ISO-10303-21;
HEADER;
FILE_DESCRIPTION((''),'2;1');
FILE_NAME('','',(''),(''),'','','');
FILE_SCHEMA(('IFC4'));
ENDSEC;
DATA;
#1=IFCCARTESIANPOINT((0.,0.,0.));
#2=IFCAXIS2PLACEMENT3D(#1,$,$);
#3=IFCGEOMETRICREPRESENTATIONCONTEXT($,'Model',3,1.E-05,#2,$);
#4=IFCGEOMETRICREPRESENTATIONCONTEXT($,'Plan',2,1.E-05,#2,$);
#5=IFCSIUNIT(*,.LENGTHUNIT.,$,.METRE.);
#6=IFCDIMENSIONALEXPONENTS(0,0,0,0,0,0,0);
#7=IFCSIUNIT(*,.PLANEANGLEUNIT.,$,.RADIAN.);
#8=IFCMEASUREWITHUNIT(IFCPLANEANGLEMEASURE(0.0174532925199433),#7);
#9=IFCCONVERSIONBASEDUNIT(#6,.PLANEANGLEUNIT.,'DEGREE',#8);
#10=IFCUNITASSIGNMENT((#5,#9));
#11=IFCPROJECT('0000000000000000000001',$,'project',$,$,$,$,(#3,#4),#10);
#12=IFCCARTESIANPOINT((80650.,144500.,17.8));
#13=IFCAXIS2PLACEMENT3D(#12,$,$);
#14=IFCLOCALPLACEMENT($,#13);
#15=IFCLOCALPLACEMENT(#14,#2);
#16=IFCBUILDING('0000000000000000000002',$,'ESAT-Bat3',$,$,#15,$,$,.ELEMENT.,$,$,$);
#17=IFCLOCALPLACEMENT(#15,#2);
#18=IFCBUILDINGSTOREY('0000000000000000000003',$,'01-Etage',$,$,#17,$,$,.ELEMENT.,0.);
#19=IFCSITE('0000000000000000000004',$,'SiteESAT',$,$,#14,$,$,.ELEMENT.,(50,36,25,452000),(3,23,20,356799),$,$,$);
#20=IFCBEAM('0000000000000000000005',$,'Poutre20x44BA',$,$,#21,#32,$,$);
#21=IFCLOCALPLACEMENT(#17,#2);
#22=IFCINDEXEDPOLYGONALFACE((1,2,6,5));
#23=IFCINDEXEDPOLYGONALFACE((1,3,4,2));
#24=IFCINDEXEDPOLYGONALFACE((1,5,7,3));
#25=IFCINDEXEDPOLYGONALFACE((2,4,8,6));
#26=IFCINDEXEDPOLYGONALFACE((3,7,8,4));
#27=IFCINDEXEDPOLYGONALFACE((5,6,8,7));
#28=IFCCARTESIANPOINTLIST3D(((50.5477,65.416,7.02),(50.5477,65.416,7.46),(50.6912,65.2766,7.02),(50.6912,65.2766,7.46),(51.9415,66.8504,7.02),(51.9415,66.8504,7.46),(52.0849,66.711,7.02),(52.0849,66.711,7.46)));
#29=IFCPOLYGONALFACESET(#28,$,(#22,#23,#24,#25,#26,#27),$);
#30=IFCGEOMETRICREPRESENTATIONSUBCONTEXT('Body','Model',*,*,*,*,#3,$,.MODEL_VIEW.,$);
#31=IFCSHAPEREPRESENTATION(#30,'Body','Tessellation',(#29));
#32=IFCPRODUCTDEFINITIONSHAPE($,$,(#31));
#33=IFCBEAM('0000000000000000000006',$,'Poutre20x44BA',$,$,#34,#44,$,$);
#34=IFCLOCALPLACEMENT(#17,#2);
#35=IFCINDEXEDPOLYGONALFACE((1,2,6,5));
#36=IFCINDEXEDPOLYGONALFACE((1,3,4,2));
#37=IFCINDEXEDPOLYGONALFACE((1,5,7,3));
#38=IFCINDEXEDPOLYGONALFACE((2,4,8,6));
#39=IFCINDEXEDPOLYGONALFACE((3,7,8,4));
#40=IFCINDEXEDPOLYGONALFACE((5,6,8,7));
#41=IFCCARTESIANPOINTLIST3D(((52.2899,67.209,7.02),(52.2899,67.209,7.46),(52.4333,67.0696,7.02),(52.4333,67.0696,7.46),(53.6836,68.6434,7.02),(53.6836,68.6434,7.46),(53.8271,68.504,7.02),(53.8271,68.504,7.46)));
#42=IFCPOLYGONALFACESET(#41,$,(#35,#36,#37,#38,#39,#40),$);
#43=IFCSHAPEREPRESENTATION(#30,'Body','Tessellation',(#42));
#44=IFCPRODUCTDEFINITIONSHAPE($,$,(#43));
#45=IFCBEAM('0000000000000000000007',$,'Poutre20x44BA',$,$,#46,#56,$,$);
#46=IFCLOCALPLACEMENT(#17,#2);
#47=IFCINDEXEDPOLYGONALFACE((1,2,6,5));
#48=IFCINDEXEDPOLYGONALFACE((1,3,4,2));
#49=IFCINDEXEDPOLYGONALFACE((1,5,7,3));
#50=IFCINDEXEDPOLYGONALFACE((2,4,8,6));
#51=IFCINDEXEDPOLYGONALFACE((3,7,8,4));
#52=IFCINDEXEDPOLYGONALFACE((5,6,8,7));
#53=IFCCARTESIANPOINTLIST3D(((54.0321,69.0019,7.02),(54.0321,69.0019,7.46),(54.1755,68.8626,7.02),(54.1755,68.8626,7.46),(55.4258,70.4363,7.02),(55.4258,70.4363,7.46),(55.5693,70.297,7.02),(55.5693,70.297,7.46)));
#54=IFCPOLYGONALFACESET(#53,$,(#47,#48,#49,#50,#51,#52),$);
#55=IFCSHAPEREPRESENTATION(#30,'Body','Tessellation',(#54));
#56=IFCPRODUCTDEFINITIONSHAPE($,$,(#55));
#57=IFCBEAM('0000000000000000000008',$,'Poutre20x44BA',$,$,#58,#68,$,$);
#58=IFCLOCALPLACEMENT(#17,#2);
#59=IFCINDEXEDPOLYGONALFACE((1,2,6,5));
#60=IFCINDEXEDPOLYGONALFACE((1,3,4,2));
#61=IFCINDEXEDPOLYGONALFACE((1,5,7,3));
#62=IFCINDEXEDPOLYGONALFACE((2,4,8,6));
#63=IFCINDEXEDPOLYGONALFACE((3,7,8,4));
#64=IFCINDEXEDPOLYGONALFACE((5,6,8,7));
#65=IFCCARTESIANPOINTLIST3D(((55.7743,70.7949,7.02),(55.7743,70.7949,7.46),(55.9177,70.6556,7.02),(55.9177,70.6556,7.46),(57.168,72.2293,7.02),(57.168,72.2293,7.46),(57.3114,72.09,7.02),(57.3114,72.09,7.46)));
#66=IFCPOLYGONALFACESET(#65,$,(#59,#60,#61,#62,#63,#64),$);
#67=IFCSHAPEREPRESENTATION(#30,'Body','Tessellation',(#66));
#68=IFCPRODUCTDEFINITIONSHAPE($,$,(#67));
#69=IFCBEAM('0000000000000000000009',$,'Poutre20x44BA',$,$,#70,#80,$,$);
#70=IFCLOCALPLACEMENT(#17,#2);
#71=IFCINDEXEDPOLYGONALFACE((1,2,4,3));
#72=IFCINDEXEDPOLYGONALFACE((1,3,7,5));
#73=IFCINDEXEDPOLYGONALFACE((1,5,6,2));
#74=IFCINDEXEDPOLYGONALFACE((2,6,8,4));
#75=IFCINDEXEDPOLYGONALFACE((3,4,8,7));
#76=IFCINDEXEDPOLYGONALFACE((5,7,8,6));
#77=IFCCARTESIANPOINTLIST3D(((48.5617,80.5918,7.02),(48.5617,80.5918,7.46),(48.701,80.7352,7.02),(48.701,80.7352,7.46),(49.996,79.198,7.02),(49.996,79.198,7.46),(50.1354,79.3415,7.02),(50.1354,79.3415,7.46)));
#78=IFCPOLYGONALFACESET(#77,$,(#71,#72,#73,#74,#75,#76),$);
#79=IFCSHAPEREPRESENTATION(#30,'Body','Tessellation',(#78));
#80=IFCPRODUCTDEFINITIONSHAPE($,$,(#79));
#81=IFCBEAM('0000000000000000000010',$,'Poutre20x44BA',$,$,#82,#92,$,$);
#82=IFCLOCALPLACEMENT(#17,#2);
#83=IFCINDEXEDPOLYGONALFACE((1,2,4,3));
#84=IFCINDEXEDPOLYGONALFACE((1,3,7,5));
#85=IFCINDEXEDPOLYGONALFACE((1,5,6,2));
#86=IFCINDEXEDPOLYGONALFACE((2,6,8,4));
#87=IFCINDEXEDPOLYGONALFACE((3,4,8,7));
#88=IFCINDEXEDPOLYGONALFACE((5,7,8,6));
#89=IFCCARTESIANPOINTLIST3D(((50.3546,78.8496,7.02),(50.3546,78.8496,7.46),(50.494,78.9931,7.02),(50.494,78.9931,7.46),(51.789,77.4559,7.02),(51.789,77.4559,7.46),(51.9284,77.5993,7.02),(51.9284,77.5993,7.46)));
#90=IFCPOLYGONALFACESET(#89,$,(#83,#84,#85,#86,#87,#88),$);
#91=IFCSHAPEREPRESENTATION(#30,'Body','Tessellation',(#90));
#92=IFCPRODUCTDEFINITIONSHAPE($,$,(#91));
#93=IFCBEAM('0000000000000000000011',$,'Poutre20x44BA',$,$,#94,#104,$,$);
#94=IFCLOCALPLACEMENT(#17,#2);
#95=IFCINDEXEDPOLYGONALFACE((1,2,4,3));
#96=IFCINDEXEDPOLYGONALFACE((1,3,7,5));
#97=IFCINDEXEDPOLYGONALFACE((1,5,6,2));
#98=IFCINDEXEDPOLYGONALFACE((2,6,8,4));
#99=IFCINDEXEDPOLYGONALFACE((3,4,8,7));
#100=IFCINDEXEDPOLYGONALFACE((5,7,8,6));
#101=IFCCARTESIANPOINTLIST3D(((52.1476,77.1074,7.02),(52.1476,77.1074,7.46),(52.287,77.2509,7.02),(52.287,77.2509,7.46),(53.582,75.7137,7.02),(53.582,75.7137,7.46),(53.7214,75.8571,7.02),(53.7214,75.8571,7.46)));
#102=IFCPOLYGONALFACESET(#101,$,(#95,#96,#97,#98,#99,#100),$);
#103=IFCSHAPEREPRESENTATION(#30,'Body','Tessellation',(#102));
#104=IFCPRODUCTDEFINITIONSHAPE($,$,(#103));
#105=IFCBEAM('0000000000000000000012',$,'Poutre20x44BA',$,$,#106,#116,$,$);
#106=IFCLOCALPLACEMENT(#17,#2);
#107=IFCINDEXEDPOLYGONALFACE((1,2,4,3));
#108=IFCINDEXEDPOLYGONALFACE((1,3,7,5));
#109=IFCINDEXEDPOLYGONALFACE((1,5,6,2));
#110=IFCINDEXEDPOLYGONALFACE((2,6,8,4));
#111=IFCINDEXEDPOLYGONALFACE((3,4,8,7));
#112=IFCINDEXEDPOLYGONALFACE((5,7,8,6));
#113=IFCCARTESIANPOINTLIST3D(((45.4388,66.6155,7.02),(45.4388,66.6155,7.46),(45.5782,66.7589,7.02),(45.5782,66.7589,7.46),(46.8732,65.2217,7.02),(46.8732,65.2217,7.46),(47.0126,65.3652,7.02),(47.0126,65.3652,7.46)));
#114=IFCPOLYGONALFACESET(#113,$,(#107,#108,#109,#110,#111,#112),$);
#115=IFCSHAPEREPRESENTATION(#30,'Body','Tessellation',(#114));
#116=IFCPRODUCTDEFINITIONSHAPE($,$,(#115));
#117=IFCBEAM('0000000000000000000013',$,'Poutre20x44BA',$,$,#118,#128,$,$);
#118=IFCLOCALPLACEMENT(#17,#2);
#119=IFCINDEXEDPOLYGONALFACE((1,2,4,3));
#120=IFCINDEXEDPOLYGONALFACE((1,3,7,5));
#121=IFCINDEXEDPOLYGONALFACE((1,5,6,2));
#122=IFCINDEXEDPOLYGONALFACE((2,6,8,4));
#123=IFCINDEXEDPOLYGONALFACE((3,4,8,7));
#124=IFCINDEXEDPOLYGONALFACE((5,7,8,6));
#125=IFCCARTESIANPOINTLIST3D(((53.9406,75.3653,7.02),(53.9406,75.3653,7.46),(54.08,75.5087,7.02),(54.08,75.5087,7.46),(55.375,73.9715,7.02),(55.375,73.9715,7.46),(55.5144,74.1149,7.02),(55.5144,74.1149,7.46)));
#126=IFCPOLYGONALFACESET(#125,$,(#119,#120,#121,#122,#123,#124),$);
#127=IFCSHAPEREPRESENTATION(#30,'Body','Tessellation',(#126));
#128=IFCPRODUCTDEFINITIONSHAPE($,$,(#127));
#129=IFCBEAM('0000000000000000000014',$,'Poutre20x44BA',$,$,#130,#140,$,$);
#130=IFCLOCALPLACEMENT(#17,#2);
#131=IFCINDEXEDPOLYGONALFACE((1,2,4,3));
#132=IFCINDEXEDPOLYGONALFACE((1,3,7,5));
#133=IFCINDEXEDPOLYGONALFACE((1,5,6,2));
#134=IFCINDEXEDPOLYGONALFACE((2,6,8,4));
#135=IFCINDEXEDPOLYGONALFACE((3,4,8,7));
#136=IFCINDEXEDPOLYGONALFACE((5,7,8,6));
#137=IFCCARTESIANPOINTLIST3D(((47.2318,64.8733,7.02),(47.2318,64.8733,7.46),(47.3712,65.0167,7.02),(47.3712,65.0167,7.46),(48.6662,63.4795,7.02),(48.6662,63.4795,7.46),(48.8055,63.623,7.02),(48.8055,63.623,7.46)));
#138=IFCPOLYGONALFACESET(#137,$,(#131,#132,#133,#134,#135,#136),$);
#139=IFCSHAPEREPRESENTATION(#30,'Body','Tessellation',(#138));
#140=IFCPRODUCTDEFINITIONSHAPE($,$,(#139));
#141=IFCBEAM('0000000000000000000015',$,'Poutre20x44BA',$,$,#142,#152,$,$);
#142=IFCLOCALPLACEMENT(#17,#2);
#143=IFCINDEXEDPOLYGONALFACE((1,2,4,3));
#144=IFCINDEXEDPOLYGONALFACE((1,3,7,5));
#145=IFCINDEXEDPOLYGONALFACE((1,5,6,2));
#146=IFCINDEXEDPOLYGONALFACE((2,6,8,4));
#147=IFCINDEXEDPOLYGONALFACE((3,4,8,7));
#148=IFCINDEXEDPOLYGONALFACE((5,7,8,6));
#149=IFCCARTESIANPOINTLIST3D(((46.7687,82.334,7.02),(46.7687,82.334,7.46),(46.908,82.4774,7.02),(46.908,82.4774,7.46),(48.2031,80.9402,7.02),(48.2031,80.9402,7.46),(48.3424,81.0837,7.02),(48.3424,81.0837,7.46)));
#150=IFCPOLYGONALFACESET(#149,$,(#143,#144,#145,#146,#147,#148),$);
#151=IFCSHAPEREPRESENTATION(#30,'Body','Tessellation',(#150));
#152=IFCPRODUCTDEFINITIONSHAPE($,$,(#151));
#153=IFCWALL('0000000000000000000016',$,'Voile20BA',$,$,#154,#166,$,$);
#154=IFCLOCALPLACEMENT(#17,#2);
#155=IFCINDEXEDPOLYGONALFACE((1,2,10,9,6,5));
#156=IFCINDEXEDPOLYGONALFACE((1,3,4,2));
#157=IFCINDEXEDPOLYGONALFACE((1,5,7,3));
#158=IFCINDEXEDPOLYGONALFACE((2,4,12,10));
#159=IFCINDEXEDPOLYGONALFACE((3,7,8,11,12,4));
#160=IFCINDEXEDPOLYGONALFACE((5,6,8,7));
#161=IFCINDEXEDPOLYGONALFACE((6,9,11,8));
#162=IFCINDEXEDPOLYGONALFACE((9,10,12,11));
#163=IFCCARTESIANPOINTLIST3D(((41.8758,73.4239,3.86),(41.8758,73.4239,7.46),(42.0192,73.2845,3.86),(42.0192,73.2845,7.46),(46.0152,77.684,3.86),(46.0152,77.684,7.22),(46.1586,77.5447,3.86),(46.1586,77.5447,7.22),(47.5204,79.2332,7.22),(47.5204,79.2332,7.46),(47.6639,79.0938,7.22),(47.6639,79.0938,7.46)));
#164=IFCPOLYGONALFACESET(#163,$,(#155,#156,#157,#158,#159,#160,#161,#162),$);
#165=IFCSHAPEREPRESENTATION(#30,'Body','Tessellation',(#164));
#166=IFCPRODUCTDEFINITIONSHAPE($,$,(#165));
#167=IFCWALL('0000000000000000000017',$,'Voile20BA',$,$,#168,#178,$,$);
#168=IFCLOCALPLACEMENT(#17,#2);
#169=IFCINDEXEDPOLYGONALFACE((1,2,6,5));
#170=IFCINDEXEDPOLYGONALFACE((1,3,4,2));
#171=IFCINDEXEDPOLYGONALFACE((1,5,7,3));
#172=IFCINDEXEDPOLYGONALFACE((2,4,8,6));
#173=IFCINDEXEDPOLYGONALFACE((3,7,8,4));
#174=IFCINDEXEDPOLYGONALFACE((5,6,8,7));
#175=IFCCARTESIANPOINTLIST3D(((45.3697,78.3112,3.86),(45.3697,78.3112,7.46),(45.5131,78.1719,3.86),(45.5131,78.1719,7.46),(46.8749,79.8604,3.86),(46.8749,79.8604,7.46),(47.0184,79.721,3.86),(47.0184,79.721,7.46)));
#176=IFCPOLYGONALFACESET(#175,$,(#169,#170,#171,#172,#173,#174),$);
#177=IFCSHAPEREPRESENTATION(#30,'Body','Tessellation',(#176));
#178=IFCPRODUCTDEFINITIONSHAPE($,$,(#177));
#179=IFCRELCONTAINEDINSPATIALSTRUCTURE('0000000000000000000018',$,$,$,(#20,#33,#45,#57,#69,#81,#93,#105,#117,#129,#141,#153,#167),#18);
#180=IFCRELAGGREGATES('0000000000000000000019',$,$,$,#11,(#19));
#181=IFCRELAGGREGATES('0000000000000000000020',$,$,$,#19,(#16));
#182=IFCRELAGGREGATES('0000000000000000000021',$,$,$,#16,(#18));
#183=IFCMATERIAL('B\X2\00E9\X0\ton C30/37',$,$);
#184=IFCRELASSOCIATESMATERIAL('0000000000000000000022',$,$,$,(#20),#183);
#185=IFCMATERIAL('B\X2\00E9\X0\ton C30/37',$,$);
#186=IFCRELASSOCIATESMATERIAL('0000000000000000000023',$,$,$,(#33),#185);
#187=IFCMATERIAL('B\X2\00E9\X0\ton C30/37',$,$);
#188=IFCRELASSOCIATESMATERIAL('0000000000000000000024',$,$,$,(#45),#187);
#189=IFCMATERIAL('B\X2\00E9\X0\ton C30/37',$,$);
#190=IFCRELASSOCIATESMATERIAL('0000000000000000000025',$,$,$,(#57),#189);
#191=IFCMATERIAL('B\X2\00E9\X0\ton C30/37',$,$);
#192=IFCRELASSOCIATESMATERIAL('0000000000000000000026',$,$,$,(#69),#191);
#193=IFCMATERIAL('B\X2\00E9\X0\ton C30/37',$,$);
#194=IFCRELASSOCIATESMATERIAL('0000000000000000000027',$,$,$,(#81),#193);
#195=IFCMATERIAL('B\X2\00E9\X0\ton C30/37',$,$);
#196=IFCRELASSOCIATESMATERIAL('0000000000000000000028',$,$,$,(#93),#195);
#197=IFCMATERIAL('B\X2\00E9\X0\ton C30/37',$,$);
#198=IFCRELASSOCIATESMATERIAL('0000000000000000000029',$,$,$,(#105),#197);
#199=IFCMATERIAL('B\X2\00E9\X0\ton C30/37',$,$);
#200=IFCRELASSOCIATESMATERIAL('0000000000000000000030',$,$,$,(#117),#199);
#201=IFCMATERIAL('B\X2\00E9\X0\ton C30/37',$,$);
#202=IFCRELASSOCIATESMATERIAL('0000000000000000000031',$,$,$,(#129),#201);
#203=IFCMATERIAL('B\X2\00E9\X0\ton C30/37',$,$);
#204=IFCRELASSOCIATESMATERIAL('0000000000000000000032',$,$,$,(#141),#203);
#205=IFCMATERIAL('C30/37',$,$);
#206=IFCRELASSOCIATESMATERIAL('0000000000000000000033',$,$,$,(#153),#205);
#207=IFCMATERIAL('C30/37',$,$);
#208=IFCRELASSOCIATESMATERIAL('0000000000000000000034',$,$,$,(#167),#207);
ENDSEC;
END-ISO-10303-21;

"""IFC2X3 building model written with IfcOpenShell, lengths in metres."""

from ifc_helpers import new_model, entity, si_unit, converted_unit, frame, frame_2d, origin, origin_with_axes, place, context, subcontext, project, spatial, polyline, rectangle, outline, extrude, material, element, save


model = new_model("IFC2X3")

# Units and contexts
model_context = context("Model", 3, precision=1e-05, world=origin())
plan_context = context("Plan", 2, precision=1e-05, world=origin())
body_context = subcontext(model_context, "Body", "Model", "MODEL_VIEW")
ifc_project = project(units=[si_unit("LENGTHUNIT", "METRE"), converted_unit("PLANEANGLEUNIT", "DEGREE", entity("IfcPlaneAngleMeasure", 0.0174532925199433), si_unit("PLANEANGLEUNIT", "RADIAN"), dimensions=[0, 0, 0, 0, 0, 0, 0])], contexts=[model_context, plan_context])

# Site, building, storey
site_placement = place(None, frame((80650.0, 144500.0, 17.8)))
site = spatial("IfcSite", under=ifc_project, at=site_placement, Name="SiteESAT", CompositionType="ELEMENT", RefLatitude=(50, 36, 25, 452000), RefLongitude=(3, 23, 20, 356799))
building_placement = place(site_placement, origin())
building = spatial("IfcBuilding", under=site, at=building_placement, Name="ESAT-Bat3", CompositionType="ELEMENT")
storey_placement = place(building_placement, origin())
storey = spatial("IfcBuildingStorey", under=building, at=storey_placement, Name="01-Etage", CompositionType="ELEMENT", Elevation=0.0)

# Beams
ifc_material_1 = material(Name="Béton C30/37")
beam_1_placement = place(storey_placement, frame((50.6912, 65.2766, 7.02), z_axis=(0.0, 0.0, 1.0), x_axis=(0.696872, 0.717196, 0.0)))
element("IfcBeam", 1, at=beam_1_placement, inside=storey, material=ifc_material_1, Name="Poutre20x44BA", context=body_context, shape_type="SweptSolid", body=[
    extrude(rectangle(XDim=0.2, YDim=0.44, at=frame_2d((0.1, 0.22), x_axis=(1.0, 0.0))), frame((0.0, 0.0, 0.0), z_axis=(1.0, 0.0, 0.0), x_axis=(0.0, 1.0, 0.0)), (0.0, 0.0, 1.0), 2.0),
])
ifc_material_2 = material(Name="Béton C30/37")
beam_2_placement = place(storey_placement, frame((52.4333, 67.0696, 7.02), z_axis=(0.0, 0.0, 1.0), x_axis=(0.696872, 0.717196, 0.0)))
element("IfcBeam", 2, at=beam_2_placement, inside=storey, material=ifc_material_2, Name="Poutre20x44BA", context=body_context, shape_type="SweptSolid", body=[
    extrude(rectangle(XDim=0.2, YDim=0.44, at=frame_2d((0.1, 0.22), x_axis=(1.0, 0.0))), frame((0.0, 0.0, 0.0), z_axis=(1.0, 0.0, 0.0), x_axis=(0.0, 1.0, 0.0)), (0.0, 0.0, 1.0), 2.0),
])
ifc_material_3 = material(Name="Béton C30/37")
beam_3_placement = place(storey_placement, frame((54.1755, 68.8626, 7.02), z_axis=(0.0, 0.0, 1.0), x_axis=(0.696872, 0.717196, 0.0)))
element("IfcBeam", 3, at=beam_3_placement, inside=storey, material=ifc_material_3, Name="Poutre20x44BA", context=body_context, shape_type="SweptSolid", body=[
    extrude(rectangle(XDim=0.2, YDim=0.44, at=frame_2d((0.1, 0.22), x_axis=(1.0, 0.0))), frame((0.0, 0.0, 0.0), z_axis=(1.0, 0.0, 0.0), x_axis=(0.0, 1.0, 0.0)), (0.0, 0.0, 1.0), 2.0),
])
ifc_material_4 = material(Name="Béton C30/37")
beam_4_placement = place(storey_placement, frame((55.9177, 70.6556, 7.02), z_axis=(0.0, 0.0, 1.0), x_axis=(0.696872, 0.717196, 0.0)))
element("IfcBeam", 4, at=beam_4_placement, inside=storey, material=ifc_material_4, Name="Poutre20x44BA", context=body_context, shape_type="SweptSolid", body=[
    extrude(rectangle(XDim=0.2, YDim=0.44, at=frame_2d((0.1, 0.22), x_axis=(1.0, 0.0))), frame((0.0, 0.0, 0.0), z_axis=(1.0, 0.0, 0.0), x_axis=(0.0, 1.0, 0.0)), (0.0, 0.0, 1.0), 2.0),
])
ifc_material_5 = material(Name="Béton C30/37")
beam_5_placement = place(storey_placement, frame((50.1354, 79.3415, 7.02), z_axis=(0.0, 0.0, 1.0), x_axis=(-0.717196, 0.696872, 0.0)))
element("IfcBeam", 5, at=beam_5_placement, inside=storey, material=ifc_material_5, Name="Poutre20x44BA", context=body_context, shape_type="SweptSolid", body=[
    extrude(rectangle(XDim=0.2, YDim=0.44, at=frame_2d((0.1, 0.22), x_axis=(1.0, 0.0))), frame((0.0, 0.0, 0.0), z_axis=(1.0, 0.0, 0.0), x_axis=(0.0, 1.0, 0.0)), (0.0, 0.0, 1.0), 2.0),
])
ifc_material_6 = material(Name="Béton C30/37")
beam_6_placement = place(storey_placement, frame((51.9284, 77.5993, 7.02), z_axis=(0.0, 0.0, 1.0), x_axis=(-0.717196, 0.696872, 0.0)))
element("IfcBeam", 6, at=beam_6_placement, inside=storey, material=ifc_material_6, Name="Poutre20x44BA", context=body_context, shape_type="SweptSolid", body=[
    extrude(rectangle(XDim=0.2, YDim=0.44, at=frame_2d((0.1, 0.22), x_axis=(1.0, 0.0))), frame((0.0, 0.0, 0.0), z_axis=(1.0, 0.0, 0.0), x_axis=(0.0, 1.0, 0.0)), (0.0, 0.0, 1.0), 2.0),
])
ifc_material_7 = material(Name="Béton C30/37")
beam_7_placement = place(storey_placement, frame((53.7214, 75.8571, 7.02), z_axis=(0.0, 0.0, 1.0), x_axis=(-0.717196, 0.696872, 0.0)))
element("IfcBeam", 7, at=beam_7_placement, inside=storey, material=ifc_material_7, Name="Poutre20x44BA", context=body_context, shape_type="SweptSolid", body=[
    extrude(rectangle(XDim=0.2, YDim=0.44, at=frame_2d((0.1, 0.22), x_axis=(1.0, 0.0))), frame((0.0, 0.0, 0.0), z_axis=(1.0, 0.0, 0.0), x_axis=(0.0, 1.0, 0.0)), (0.0, 0.0, 1.0), 2.0),
])
ifc_material_8 = material(Name="Béton C30/37")
beam_8_placement = place(storey_placement, frame((47.0126, 65.3652, 7.02), z_axis=(0.0, 0.0, 1.0), x_axis=(-0.717196, 0.696872, 0.0)))
element("IfcBeam", 8, at=beam_8_placement, inside=storey, material=ifc_material_8, Name="Poutre20x44BA", context=body_context, shape_type="SweptSolid", body=[
    extrude(rectangle(XDim=0.2, YDim=0.44, at=frame_2d((0.1, 0.22), x_axis=(1.0, 0.0))), frame((0.0, 0.0, 0.0), z_axis=(1.0, 0.0, 0.0), x_axis=(0.0, 1.0, 0.0)), (0.0, 0.0, 1.0), 2.0),
])
ifc_material_9 = material(Name="Béton C30/37")
beam_9_placement = place(storey_placement, frame((55.5144, 74.1149, 7.02), z_axis=(0.0, 0.0, 1.0), x_axis=(-0.717196, 0.696872, 0.0)))
element("IfcBeam", 9, at=beam_9_placement, inside=storey, material=ifc_material_9, Name="Poutre20x44BA", context=body_context, shape_type="SweptSolid", body=[
    extrude(rectangle(XDim=0.2, YDim=0.44, at=frame_2d((0.1, 0.22), x_axis=(1.0, 0.0))), frame((0.0, 0.0, 0.0), z_axis=(1.0, 0.0, 0.0), x_axis=(0.0, 1.0, 0.0)), (0.0, 0.0, 1.0), 2.0),
])
ifc_material_10 = material(Name="Béton C30/37")
beam_10_placement = place(storey_placement, frame((48.8055, 63.623, 7.02), z_axis=(0.0, 0.0, 1.0), x_axis=(-0.717196, 0.696872, 0.0)))
element("IfcBeam", 10, at=beam_10_placement, inside=storey, material=ifc_material_10, Name="Poutre20x44BA", context=body_context, shape_type="SweptSolid", body=[
    extrude(rectangle(XDim=0.2, YDim=0.44, at=frame_2d((0.1, 0.22), x_axis=(1.0, 0.0))), frame((0.0, 0.0, 0.0), z_axis=(1.0, 0.0, 0.0), x_axis=(0.0, 1.0, 0.0)), (0.0, 0.0, 1.0), 2.0),
])
ifc_material_11 = material(Name="Béton C30/37")
beam_11_placement = place(storey_placement, frame((48.3424, 81.0837, 7.02), z_axis=(0.0, 0.0, 1.0), x_axis=(-0.717196, 0.696872, 0.0)))
element("IfcBeam", 11, at=beam_11_placement, inside=storey, material=ifc_material_11, Name="Poutre20x44BA", context=body_context, shape_type="SweptSolid", body=[
    extrude(rectangle(XDim=0.2, YDim=0.44, at=frame_2d((0.1, 0.22), x_axis=(1.0, 0.0))), frame((0.0, 0.0, 0.0), z_axis=(1.0, 0.0, 0.0), x_axis=(0.0, 1.0, 0.0)), (0.0, 0.0, 1.0), 2.0),
])

# Wall, opening
ifc_material_12 = material(Name="C30/37")
wall_1_placement = place(storey_placement, frame((47.5204, 79.2332, 3.86), z_axis=(0.0, 0.0, 1.0), x_axis=(-0.696872, -0.717196, 0.0)))
wall_1 = element("IfcWall", 12, at=wall_1_placement, inside=storey, material=ifc_material_12, Name="Voile20BA", context=body_context, shape_type="SweptSolid", body=[
    extrude(rectangle(XDim=8.1, YDim=0.2, at=frame_2d((4.05, 0.1), x_axis=(1.0, 0.0))), origin_with_axes(), (0.0, 0.0, 1.0), 3.6),
])
opening_placement = place(wall_1_placement, frame((2.16, 0.2, 0.0), z_axis=(0.0, -1.0, 0.0), x_axis=(0.0, 0.0, 1.0)))
element("IfcOpeningElement", 13, at=opening_placement, cuts=wall_1, ObjectType="Opening", context=body_context, shape_type="SweptSolid", body=[
    extrude(outline(polyline([(0.0, 2.16), (3.36, 2.16), (3.36, 0.0), (0.0, 0.0), (0.0, 2.16)])), origin_with_axes(), (0.0, 0.0, 1.0), 0.2),
])

# Wall
ifc_material_13 = material(Name="C30/37")
wall_2_placement = place(storey_placement, frame((46.8749, 79.8604, 3.86), z_axis=(0.0, 0.0, 1.0), x_axis=(-0.696872, -0.717196, 0.0)))
element("IfcWall", 14, at=wall_2_placement, inside=storey, material=ifc_material_13, Name="Voile20BA", context=body_context, shape_type="SweptSolid", body=[
    extrude(rectangle(XDim=2.16, YDim=0.2, at=frame_2d((1.08, 0.1), x_axis=(1.0, 0.0))), origin_with_axes(), (0.0, 0.0, 1.0), 3.6),
])

save(model, "model.ifc")
